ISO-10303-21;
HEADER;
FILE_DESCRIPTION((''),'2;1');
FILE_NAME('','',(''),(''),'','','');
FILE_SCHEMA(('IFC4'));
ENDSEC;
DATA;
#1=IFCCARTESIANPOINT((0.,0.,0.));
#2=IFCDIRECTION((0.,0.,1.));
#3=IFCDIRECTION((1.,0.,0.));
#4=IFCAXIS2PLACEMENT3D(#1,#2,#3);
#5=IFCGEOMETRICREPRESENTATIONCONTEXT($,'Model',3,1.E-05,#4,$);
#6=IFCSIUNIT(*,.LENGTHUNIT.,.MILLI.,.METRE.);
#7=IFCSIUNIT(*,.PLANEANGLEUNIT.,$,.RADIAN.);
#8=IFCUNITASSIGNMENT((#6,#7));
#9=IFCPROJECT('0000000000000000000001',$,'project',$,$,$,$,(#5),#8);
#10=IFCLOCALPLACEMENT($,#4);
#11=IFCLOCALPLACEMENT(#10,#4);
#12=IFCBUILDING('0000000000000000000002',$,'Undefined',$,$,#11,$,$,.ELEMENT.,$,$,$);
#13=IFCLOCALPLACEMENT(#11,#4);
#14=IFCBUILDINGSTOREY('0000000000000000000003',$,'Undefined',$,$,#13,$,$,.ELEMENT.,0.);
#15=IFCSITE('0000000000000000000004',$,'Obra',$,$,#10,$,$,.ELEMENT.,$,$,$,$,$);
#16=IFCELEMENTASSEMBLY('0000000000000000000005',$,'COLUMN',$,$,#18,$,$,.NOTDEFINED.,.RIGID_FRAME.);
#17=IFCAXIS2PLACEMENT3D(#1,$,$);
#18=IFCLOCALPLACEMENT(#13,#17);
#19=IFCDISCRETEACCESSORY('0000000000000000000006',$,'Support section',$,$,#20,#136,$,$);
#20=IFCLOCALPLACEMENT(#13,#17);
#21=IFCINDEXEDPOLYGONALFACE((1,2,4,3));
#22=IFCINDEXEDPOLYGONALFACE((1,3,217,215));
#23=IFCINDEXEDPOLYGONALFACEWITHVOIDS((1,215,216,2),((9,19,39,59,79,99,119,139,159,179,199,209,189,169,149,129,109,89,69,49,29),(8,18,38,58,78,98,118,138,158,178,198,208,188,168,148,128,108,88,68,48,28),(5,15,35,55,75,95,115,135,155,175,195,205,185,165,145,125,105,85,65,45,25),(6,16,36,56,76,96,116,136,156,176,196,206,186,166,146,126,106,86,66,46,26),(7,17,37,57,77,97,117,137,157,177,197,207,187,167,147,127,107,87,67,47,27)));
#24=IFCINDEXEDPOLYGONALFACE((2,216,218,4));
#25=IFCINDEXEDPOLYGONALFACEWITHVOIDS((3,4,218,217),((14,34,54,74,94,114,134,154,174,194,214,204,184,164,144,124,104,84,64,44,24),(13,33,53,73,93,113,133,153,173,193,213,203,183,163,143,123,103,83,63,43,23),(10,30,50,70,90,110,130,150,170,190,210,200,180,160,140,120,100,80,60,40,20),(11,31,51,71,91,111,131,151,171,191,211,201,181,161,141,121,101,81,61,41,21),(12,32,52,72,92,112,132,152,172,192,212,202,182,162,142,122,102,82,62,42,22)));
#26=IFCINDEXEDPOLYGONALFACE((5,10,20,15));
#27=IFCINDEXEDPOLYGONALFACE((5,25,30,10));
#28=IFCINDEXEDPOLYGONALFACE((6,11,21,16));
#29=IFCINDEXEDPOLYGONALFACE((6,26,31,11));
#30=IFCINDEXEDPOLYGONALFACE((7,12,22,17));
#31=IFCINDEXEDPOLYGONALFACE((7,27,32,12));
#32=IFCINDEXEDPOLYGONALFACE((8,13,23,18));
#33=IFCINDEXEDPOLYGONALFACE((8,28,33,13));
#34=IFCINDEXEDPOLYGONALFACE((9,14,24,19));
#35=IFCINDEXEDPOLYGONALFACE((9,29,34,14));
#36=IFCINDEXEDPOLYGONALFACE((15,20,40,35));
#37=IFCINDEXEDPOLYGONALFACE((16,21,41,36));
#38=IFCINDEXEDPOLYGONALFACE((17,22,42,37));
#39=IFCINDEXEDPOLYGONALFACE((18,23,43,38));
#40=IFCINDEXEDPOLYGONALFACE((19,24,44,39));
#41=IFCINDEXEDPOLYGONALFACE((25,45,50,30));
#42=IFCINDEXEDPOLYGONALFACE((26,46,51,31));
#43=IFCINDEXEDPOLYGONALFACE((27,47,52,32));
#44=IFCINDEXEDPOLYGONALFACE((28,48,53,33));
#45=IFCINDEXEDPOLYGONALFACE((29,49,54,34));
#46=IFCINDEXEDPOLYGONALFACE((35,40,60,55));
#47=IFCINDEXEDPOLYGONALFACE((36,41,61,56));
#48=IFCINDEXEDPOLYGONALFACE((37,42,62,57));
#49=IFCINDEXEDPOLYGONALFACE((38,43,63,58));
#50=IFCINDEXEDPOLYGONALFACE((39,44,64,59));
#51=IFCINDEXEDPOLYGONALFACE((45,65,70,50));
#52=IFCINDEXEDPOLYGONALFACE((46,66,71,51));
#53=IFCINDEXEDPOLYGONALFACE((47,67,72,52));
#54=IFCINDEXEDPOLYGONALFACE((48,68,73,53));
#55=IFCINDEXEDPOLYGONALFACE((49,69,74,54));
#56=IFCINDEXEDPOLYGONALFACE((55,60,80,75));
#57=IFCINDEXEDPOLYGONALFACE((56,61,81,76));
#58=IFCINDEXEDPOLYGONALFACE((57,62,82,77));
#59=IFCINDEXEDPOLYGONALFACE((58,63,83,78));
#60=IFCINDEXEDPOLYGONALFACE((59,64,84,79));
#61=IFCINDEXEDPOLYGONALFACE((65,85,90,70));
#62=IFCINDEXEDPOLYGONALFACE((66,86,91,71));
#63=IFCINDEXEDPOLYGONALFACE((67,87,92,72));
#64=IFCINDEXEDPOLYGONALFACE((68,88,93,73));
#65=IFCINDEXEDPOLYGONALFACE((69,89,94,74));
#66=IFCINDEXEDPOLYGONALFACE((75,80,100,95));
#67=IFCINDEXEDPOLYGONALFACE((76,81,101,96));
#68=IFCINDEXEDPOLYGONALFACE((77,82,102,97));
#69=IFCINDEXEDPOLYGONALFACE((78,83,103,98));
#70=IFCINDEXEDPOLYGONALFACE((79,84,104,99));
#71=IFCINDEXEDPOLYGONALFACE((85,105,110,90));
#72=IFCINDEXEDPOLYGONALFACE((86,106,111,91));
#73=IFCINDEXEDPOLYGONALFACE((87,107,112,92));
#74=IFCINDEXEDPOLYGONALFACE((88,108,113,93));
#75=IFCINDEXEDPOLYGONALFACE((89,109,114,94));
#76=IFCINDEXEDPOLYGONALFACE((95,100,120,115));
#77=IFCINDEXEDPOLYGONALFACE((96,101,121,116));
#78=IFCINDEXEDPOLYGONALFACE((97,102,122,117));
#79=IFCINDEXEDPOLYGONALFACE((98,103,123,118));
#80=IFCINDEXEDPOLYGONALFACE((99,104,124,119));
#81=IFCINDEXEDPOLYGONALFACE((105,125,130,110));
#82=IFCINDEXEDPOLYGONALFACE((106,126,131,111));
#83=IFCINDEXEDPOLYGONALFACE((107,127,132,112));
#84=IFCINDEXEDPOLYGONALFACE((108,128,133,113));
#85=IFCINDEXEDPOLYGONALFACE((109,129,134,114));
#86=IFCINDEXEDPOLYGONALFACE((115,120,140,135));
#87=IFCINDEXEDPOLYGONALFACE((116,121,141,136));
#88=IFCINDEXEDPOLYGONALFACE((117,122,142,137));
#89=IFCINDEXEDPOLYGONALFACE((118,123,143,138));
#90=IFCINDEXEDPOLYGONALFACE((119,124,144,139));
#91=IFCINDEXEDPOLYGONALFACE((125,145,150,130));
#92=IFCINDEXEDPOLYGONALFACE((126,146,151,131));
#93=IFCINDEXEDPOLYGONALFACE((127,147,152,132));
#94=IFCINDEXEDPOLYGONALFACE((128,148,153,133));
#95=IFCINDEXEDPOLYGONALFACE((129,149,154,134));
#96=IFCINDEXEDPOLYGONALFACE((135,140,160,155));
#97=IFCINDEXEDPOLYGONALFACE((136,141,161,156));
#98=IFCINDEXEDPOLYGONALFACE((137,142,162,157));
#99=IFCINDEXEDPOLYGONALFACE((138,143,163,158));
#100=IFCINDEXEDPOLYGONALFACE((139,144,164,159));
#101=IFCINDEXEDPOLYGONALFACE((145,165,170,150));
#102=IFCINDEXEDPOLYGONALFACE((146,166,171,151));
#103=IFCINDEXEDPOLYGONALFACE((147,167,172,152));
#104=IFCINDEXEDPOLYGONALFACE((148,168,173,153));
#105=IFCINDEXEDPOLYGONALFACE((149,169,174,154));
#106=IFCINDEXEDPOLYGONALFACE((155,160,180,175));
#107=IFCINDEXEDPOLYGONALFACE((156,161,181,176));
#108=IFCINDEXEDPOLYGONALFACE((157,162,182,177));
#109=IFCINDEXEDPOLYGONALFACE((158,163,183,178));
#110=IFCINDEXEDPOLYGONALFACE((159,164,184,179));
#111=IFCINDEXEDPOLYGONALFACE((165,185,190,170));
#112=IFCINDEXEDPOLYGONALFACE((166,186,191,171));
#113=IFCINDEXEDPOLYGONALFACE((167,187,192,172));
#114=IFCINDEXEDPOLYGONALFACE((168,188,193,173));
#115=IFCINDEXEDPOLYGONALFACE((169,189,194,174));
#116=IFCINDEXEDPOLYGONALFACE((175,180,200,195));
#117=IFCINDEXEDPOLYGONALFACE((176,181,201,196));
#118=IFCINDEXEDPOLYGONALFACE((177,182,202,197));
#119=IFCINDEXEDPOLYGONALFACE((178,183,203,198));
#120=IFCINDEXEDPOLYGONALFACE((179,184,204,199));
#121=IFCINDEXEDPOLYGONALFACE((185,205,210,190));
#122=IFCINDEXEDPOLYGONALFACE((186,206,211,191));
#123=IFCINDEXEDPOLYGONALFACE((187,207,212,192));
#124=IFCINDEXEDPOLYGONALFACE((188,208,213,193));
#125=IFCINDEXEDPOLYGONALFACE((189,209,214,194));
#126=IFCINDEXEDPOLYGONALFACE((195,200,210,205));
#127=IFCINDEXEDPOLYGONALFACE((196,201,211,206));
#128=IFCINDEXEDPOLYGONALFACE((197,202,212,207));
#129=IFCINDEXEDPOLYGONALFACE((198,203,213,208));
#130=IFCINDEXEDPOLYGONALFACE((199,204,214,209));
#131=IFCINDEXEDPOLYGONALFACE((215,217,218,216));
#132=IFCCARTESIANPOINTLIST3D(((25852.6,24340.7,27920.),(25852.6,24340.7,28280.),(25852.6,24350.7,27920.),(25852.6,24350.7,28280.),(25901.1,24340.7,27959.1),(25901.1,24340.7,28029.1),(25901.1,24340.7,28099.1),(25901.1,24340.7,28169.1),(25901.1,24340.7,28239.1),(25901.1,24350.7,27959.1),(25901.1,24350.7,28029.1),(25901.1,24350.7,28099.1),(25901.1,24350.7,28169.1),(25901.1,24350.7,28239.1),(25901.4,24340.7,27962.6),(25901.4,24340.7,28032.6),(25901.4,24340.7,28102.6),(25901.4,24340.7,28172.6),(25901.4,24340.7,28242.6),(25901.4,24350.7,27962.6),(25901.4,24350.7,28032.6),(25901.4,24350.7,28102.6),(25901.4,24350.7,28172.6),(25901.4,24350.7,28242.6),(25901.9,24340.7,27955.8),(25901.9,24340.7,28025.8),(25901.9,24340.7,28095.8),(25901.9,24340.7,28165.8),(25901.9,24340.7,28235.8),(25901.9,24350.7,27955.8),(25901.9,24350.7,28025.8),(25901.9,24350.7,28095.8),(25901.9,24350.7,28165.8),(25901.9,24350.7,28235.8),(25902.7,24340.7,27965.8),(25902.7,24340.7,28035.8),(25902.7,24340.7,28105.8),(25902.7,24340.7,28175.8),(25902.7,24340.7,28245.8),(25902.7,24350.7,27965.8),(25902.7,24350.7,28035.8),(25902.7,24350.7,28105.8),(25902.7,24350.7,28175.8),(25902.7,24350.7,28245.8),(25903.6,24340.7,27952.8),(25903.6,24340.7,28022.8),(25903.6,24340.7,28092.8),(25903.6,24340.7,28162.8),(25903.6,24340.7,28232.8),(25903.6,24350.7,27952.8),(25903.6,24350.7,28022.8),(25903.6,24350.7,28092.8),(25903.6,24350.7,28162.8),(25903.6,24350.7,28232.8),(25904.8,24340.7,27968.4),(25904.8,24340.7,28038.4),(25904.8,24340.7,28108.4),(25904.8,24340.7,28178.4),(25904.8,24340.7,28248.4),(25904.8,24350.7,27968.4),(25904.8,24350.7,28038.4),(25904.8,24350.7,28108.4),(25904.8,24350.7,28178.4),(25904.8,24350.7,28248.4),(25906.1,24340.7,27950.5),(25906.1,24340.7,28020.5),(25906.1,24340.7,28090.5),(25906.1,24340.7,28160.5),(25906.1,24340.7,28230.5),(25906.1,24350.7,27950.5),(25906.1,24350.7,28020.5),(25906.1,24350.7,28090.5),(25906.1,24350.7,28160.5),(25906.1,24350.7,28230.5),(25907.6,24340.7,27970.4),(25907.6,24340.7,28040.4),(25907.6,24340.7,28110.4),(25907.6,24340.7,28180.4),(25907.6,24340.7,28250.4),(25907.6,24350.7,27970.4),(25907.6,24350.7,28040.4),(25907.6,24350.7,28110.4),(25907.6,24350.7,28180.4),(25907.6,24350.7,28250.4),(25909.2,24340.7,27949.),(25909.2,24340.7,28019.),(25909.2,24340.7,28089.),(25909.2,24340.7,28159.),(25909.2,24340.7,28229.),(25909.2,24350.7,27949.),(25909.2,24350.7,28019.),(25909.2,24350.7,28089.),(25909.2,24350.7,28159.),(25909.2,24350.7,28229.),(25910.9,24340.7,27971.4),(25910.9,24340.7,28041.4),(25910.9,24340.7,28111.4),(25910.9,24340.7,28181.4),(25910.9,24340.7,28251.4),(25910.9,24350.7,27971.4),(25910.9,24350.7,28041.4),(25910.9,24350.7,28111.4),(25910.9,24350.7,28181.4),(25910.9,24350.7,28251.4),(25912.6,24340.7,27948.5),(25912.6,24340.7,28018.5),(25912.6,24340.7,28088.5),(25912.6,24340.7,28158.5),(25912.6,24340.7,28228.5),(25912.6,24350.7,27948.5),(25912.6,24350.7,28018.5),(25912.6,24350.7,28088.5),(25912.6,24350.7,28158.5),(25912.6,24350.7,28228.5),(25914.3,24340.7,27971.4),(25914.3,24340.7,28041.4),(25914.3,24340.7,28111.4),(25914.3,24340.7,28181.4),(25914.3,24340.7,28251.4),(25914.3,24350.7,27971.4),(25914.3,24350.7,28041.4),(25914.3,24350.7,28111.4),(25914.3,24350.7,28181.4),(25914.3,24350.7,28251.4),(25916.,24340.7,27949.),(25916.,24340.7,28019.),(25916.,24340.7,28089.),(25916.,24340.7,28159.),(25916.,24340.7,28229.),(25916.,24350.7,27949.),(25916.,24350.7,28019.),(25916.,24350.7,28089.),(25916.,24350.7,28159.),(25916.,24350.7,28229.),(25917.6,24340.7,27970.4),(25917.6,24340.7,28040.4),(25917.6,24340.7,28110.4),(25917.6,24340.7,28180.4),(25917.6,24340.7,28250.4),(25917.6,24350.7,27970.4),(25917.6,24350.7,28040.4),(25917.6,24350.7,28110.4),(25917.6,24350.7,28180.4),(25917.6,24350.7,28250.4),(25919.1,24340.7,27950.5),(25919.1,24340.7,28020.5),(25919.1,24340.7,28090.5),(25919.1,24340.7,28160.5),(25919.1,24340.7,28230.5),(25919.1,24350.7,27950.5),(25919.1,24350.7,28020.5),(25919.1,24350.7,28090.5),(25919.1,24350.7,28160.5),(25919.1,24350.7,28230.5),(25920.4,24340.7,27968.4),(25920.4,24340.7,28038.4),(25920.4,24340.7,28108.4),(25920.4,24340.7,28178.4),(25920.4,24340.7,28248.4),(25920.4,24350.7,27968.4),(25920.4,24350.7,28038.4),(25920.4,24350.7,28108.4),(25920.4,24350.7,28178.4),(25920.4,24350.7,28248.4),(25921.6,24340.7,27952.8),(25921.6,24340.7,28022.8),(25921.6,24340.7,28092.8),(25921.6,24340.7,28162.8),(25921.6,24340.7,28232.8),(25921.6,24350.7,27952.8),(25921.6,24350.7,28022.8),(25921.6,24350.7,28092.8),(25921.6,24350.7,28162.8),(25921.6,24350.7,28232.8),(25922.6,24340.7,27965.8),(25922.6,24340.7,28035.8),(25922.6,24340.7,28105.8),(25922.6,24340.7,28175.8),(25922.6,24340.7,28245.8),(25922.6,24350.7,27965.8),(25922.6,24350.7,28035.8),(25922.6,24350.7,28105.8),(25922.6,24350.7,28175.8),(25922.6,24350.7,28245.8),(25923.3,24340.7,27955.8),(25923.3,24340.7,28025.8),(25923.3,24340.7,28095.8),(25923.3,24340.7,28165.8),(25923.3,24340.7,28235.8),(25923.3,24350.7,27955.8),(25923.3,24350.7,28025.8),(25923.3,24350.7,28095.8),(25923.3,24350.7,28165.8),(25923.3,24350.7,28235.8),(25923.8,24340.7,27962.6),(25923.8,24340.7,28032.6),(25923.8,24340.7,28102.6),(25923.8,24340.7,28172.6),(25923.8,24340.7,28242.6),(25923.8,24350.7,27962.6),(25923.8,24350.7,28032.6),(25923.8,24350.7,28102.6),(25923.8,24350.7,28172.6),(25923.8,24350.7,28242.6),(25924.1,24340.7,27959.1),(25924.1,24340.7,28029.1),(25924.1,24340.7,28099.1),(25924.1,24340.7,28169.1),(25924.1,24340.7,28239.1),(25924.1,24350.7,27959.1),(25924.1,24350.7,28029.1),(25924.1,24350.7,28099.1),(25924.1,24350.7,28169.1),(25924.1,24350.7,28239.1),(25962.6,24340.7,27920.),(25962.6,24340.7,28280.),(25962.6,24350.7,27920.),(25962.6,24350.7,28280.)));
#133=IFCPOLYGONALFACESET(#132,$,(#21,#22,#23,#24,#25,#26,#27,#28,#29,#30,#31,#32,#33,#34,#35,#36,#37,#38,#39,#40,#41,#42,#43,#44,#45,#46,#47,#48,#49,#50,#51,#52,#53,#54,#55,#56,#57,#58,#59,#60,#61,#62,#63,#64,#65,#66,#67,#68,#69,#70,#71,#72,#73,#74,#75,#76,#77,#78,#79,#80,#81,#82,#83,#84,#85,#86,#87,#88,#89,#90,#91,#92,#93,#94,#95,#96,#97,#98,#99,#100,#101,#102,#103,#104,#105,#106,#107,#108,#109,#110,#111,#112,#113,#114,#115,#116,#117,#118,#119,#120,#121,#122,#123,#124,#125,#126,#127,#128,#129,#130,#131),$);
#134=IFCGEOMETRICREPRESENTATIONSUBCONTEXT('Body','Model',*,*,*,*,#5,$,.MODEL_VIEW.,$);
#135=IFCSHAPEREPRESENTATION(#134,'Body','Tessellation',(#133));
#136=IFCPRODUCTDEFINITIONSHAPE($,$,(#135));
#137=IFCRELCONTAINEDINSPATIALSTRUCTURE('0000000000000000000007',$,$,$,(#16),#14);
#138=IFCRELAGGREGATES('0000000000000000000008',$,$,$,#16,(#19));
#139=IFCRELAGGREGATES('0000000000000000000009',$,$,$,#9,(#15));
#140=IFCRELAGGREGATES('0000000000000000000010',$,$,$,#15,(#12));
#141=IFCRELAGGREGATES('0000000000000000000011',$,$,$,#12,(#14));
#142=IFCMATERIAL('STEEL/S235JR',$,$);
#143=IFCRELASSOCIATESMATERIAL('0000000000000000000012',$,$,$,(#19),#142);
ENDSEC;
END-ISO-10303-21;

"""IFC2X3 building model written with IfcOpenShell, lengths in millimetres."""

from ifc_helpers import new_model, si_unit, frame, origin_with_axes, origin_2d_with_axis, place, context, subcontext, project, spatial, rectangle, circle, extrude, source, transform, mapped, material, element, aggregate, save


model = new_model("IFC2X3")

# Units and contexts
model_context = context("Model", 3, precision=1e-05, world=origin_with_axes())
body_context = subcontext(model_context, "Body", "Model", "MODEL_VIEW")
ifc_project = project(units=[si_unit("LENGTHUNIT", "METRE", prefix="MILLI"), si_unit("PLANEANGLEUNIT", "RADIAN")], contexts=[model_context])

# Site, building, storey
site_placement = place(None, origin_with_axes())
site = spatial("IfcSite", under=ifc_project, at=site_placement, Name="Obra", CompositionType="ELEMENT")
building_placement = place(site_placement, origin_with_axes())
building = spatial("IfcBuilding", under=site, at=building_placement, Name="Undefined", CompositionType="ELEMENT")
storey_placement = place(building_placement, origin_with_axes())
storey = spatial("IfcBuildingStorey", under=building, at=storey_placement, Name="Undefined", CompositionType="ELEMENT", Elevation=0.0)

# Shared definitions
ifc_material_1 = material(Name="STEEL/S235JR")

# Element assembly
assembly_1_placement = place(storey_placement, origin_with_axes())
assembly_1 = element("IfcElementAssembly", 1, at=assembly_1_placement, inside=storey, Name="COLUMN", AssemblyPlace="NOTDEFINED", PredefinedType="RIGID_FRAME")
shared_shape_1 = source(origin_with_axes(), body_context, "Body", "SweptSolid", [
    extrude(circle(Radius=11.5, at=origin_2d_with_axis()), frame((0.0, -14.4, 0.0), z_axis=(0.0, 1.0, 0.0), x_axis=(1.0, 0.0, 0.0)), (0.0, 0.0, 1.0), 10.2),
])

# Discrete accessory, opening
discrete_accessory_1_placement = place(assembly_1_placement, frame((25907.6, 24345.7, 27920.0), z_axis=(0.0, 0.0, 1.0), x_axis=(-1.0, 0.0, 0.0)))
discrete_accessory_1 = element("IfcDiscreteAccessory", 2, at=discrete_accessory_1_placement, material=ifc_material_1, Name="Support section", context=body_context, shape_type="SweptSolid", body=[
    extrude(rectangle(XDim=10.0, YDim=110.0, at=origin_2d_with_axis()), frame((0.0, 0.0, 360.0), z_axis=(0.0, 0.0, -1.0), x_axis=(0.0, 1.0, 0.0)), (0.0, 0.0, 1.0), 360.0),
])
opening_1_placement = place(assembly_1_placement, frame((25862.6, 24355.0, 28300.0), z_axis=(1.0, 0.0, 0.0), x_axis=(0.0, 0.0, -1.0)))
element("IfcOpeningElement", 3, at=opening_1_placement, cuts=discrete_accessory_1, ObjectType="Opening", context=body_context, shape_type="MappedRepresentation", body=[
    mapped(shared_shape_1, transform((60.0, 0.0, 50.0))),
    mapped(shared_shape_1, transform((130.0, 0.0, 50.0))),
    mapped(shared_shape_1, transform((200.0, 0.0, 50.0))),
    mapped(shared_shape_1, transform((270.0, 0.0, 50.0))),
    mapped(shared_shape_1, transform((340.0, 0.0, 50.0))),
])
aggregate(assembly_1, [discrete_accessory_1])

save(model, "model.ifc")
